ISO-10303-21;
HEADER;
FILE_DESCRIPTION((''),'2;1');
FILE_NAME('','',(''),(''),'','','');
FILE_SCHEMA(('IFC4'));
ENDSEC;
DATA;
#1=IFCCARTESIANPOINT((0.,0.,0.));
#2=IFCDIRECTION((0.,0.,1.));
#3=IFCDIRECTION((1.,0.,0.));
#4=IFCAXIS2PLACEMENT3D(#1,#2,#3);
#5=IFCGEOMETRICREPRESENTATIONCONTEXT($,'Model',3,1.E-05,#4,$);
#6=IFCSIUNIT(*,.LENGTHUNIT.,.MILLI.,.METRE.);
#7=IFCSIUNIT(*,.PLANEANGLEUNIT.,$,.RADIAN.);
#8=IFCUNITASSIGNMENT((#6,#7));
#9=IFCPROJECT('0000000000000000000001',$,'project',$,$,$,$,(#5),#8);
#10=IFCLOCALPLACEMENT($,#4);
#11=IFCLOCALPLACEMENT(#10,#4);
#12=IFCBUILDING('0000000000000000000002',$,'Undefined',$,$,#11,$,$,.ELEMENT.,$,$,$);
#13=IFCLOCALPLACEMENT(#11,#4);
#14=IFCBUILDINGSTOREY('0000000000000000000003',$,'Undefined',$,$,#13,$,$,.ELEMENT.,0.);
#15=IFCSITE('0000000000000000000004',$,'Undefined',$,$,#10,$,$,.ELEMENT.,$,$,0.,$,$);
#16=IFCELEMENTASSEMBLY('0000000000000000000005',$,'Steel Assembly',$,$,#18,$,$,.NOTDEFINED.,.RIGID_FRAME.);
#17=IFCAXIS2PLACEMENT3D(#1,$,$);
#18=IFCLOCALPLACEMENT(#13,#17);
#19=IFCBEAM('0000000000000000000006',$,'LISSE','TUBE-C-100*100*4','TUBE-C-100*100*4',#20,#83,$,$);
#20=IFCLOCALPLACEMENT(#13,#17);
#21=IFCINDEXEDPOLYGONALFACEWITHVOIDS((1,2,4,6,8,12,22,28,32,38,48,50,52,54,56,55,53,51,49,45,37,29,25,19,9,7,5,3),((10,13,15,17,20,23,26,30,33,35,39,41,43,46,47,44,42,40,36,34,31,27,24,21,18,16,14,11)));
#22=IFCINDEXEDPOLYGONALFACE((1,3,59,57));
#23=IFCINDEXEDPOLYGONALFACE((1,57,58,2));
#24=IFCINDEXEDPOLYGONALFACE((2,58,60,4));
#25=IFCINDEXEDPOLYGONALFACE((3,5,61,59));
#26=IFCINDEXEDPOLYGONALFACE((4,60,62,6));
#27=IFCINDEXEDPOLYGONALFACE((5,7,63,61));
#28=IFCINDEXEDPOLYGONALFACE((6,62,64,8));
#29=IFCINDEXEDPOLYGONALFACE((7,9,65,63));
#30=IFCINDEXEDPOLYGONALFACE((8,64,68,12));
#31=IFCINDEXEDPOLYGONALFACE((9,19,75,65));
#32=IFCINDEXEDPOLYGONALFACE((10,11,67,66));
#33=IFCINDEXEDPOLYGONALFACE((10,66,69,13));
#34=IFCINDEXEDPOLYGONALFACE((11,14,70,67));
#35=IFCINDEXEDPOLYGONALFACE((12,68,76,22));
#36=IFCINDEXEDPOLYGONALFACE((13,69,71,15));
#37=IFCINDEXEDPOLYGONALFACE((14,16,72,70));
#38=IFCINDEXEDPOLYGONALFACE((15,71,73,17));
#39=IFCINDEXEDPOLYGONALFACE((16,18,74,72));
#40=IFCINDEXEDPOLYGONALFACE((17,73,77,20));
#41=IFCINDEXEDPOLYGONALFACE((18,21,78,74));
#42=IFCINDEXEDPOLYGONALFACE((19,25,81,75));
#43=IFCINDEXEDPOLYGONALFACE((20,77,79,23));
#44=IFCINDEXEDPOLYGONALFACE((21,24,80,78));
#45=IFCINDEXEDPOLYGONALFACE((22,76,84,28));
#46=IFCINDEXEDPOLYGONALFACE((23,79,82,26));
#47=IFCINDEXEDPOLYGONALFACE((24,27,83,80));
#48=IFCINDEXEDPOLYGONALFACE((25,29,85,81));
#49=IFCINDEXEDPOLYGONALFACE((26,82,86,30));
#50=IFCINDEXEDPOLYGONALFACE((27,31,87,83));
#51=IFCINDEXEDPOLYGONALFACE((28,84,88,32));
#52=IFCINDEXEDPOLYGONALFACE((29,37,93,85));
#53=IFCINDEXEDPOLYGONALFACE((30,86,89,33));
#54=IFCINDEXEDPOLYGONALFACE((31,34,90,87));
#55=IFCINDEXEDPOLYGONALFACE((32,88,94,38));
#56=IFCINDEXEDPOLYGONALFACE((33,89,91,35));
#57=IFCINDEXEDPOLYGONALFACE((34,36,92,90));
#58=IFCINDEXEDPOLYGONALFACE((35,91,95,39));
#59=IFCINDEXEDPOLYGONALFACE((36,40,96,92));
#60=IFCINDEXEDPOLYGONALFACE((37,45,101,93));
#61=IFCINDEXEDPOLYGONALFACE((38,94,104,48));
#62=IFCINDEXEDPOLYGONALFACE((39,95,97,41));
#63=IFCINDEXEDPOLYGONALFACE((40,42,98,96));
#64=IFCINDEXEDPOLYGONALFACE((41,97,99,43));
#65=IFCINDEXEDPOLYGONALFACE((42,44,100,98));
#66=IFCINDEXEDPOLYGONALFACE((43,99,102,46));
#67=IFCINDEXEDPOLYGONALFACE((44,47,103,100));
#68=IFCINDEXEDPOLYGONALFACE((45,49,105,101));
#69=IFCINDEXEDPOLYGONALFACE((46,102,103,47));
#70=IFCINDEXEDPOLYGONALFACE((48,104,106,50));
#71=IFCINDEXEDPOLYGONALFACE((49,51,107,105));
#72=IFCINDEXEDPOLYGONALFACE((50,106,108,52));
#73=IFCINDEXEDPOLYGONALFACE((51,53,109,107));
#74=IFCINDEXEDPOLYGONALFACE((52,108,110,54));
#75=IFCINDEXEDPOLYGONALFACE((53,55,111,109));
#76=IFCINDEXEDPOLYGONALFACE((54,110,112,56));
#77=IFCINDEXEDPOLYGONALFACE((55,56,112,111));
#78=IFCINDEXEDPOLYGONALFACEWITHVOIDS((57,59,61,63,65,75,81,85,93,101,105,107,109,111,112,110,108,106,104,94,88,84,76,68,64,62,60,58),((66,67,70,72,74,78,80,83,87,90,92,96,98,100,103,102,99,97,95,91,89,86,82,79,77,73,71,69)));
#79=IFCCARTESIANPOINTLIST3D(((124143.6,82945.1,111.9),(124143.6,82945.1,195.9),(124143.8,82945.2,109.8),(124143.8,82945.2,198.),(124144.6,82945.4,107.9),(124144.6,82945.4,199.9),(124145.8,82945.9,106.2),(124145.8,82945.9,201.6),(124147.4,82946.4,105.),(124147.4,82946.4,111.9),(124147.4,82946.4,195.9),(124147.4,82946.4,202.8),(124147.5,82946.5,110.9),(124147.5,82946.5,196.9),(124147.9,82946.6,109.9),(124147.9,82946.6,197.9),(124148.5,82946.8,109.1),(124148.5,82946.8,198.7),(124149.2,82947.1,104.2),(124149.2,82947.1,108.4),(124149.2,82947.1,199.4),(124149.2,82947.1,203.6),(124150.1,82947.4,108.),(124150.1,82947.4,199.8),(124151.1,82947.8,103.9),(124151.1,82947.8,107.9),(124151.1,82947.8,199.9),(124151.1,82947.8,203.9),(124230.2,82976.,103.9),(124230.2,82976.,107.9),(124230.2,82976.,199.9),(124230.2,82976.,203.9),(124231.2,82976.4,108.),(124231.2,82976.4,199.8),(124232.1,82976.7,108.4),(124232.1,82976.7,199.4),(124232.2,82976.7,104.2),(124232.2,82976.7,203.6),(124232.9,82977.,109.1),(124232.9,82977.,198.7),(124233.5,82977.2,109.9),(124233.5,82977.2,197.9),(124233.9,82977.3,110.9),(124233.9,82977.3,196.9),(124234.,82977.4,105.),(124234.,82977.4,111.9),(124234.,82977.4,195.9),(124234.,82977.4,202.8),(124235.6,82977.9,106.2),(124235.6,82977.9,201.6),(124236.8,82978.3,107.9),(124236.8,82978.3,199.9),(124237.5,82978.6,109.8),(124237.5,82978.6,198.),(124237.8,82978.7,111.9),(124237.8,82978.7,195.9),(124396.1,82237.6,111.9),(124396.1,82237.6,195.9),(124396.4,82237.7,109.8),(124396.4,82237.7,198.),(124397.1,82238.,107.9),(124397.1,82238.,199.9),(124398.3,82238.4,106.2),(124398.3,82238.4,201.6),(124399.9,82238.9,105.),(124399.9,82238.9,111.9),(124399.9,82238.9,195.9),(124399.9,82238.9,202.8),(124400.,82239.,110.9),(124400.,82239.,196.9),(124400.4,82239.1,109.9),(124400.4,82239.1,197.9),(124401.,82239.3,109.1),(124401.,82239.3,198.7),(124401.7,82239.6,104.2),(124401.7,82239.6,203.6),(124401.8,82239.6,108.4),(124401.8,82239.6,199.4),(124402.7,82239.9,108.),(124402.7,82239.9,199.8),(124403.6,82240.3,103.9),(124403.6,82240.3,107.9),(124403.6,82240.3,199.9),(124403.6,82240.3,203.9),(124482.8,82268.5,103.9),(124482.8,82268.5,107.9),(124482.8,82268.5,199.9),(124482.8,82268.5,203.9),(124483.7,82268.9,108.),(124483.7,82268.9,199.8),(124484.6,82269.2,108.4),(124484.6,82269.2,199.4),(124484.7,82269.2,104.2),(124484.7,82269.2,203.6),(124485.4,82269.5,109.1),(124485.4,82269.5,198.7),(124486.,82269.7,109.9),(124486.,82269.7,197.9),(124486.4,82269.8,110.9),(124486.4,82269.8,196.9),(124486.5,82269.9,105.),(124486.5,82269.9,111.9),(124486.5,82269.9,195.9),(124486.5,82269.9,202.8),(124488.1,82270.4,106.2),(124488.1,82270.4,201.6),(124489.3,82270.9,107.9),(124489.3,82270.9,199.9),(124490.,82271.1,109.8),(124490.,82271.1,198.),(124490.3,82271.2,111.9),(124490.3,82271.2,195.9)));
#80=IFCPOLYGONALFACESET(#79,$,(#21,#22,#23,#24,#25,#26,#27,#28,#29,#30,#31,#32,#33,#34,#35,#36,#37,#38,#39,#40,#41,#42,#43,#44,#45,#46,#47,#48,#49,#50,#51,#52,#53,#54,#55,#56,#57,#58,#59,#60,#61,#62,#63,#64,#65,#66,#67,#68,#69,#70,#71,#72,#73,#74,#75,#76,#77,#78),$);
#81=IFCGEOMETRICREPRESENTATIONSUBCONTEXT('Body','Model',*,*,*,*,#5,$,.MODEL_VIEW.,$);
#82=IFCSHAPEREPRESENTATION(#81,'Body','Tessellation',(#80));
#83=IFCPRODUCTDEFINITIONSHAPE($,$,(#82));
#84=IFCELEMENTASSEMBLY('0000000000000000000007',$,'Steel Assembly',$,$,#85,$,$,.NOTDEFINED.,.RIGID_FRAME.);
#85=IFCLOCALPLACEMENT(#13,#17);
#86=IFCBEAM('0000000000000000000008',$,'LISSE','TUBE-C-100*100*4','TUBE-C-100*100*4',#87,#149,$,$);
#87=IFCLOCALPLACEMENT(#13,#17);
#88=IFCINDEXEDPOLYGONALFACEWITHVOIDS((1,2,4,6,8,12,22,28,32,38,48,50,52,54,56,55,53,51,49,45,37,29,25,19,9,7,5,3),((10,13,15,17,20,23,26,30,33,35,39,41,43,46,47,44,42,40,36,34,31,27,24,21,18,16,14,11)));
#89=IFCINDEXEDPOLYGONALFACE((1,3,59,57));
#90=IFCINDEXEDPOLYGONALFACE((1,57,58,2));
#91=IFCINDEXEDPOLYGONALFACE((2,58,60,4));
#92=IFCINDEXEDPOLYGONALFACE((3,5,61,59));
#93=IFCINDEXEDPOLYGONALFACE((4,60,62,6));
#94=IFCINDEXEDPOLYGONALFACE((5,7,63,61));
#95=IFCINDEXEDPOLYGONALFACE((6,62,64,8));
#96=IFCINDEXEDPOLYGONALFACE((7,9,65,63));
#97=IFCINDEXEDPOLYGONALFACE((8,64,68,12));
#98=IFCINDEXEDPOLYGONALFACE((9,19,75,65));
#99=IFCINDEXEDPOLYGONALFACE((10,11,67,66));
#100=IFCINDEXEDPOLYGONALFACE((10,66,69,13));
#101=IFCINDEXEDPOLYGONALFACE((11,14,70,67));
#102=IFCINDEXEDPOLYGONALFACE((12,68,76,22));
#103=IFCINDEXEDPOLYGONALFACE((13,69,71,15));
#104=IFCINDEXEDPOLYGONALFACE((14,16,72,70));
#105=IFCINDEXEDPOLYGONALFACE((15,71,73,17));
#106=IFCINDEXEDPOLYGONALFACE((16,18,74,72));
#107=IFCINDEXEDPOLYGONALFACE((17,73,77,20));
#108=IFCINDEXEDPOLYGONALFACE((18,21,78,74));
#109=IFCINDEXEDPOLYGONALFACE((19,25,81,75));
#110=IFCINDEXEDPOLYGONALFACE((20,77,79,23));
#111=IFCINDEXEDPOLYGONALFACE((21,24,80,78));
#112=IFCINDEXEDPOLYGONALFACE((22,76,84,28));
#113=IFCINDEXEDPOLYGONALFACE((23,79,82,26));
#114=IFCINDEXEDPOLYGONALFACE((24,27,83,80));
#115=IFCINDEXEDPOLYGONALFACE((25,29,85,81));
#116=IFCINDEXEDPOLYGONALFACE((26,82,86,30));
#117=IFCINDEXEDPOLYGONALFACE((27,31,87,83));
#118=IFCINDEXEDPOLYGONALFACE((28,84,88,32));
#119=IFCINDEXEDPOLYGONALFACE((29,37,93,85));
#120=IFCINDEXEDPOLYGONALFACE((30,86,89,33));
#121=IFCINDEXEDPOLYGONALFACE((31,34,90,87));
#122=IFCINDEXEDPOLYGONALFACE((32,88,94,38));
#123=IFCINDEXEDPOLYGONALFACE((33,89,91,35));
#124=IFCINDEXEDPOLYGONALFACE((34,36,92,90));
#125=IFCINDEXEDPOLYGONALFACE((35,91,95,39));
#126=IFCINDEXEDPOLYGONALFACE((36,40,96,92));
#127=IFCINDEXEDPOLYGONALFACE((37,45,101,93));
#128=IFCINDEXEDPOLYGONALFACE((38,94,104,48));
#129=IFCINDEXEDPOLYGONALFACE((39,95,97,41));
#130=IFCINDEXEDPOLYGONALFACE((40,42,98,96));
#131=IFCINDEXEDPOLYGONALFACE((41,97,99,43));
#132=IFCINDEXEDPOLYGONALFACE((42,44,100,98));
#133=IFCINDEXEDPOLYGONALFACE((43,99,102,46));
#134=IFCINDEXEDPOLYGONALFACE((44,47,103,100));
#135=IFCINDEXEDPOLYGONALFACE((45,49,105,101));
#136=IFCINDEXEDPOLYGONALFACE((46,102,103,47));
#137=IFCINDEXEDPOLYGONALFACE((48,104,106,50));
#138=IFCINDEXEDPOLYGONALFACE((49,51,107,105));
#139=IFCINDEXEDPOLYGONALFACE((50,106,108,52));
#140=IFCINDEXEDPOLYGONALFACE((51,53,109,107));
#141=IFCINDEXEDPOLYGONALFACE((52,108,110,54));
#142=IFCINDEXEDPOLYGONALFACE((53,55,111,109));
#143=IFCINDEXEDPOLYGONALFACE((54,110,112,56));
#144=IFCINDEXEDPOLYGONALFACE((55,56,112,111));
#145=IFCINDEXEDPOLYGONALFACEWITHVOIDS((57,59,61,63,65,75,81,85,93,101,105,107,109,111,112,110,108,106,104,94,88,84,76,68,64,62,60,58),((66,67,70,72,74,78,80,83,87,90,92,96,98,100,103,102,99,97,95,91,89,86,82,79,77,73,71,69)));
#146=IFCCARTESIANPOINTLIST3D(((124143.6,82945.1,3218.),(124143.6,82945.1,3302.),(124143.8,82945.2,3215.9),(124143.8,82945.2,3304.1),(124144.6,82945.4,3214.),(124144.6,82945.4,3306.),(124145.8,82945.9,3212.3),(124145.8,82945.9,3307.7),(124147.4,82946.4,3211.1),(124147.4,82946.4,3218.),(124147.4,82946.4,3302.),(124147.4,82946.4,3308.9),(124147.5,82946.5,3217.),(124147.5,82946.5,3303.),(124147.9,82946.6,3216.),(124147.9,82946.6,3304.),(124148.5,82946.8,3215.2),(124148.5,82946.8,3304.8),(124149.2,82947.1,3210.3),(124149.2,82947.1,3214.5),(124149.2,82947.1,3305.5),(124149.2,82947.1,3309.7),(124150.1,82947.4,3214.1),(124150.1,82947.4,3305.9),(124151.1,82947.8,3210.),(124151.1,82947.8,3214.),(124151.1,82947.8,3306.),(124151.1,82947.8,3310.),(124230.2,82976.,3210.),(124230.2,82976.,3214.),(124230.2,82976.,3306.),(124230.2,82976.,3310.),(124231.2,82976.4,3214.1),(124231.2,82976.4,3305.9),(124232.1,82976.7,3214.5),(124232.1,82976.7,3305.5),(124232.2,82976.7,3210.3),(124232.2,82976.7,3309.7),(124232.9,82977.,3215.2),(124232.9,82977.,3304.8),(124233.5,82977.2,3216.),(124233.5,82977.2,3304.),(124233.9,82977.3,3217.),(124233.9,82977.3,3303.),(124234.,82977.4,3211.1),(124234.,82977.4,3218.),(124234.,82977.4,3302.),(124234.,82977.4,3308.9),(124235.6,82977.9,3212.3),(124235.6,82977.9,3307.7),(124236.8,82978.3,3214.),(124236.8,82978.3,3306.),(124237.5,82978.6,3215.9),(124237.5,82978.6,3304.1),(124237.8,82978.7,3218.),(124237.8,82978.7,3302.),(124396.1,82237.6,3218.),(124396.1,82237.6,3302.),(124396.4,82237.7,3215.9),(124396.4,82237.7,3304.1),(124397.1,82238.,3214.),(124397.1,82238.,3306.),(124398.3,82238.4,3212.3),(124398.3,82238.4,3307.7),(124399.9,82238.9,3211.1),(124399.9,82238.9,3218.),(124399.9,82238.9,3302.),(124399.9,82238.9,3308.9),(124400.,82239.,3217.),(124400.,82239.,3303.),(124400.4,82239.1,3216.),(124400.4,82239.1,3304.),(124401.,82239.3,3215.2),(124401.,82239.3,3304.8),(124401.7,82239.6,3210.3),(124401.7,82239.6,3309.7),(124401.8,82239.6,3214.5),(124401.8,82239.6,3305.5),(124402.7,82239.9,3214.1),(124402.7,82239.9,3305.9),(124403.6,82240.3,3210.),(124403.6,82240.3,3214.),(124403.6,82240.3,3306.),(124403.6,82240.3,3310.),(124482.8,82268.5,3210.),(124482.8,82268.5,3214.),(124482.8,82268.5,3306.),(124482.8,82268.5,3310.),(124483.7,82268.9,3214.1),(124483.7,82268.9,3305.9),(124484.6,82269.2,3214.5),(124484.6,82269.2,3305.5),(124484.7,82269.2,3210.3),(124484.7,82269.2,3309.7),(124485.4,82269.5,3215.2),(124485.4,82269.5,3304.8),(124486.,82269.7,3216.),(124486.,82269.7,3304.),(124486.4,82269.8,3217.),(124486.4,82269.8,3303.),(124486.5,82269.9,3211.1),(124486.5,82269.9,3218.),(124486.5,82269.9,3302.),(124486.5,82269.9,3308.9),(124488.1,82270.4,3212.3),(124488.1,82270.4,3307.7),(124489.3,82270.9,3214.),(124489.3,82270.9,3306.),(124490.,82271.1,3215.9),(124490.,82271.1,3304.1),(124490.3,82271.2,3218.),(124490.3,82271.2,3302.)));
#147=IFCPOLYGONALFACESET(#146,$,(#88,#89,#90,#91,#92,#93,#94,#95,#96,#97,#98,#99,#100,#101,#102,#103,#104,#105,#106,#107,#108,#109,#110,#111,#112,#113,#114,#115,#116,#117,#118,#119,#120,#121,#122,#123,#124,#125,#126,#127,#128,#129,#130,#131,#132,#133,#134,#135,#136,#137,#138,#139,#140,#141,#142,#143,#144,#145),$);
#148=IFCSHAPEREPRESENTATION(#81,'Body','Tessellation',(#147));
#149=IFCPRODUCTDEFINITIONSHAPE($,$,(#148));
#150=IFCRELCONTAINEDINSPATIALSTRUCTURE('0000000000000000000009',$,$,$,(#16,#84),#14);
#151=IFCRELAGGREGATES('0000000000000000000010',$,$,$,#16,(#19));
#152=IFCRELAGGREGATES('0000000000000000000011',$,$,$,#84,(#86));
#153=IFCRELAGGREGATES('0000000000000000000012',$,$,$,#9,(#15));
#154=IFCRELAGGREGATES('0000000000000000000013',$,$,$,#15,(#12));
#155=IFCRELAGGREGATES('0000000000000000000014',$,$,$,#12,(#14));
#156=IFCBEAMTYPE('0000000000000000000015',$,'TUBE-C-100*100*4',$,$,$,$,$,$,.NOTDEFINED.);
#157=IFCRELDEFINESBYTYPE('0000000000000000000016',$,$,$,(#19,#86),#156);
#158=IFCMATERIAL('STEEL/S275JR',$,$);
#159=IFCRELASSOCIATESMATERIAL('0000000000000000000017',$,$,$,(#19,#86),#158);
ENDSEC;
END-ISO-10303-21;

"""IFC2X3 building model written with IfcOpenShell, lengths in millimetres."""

from ifc_helpers import new_model, si_unit, frame, origin_with_axes, origin_2d_with_axis, place, context, subcontext, project, spatial, hollow_rectangle, extrude, material, type_object, element, aggregate, save


model = new_model("IFC2X3")

# Units and contexts
model_context = context("Model", 3, precision=1e-05, world=origin_with_axes())
body_context = subcontext(model_context, "Body", "Model", "MODEL_VIEW")
ifc_project = project(units=[si_unit("LENGTHUNIT", "METRE", prefix="MILLI"), si_unit("PLANEANGLEUNIT", "RADIAN")], contexts=[model_context])

# Site, building, storey
site_placement = place(None, origin_with_axes())
site = spatial("IfcSite", under=ifc_project, at=site_placement, Name="Undefined", CompositionType="ELEMENT", RefElevation=0.0)
building_placement = place(site_placement, origin_with_axes())
building = spatial("IfcBuilding", under=site, at=building_placement, Name="Undefined", CompositionType="ELEMENT")
storey_placement = place(building_placement, origin_with_axes())
storey = spatial("IfcBuildingStorey", under=building, at=storey_placement, Name="Undefined", CompositionType="ELEMENT", Elevation=0.0)

# Shared definitions
ifc_material = material(Name="STEEL/S275JR")

# Element assemblies, beams
beam_type_1 = type_object("IfcBeamType", Name="TUBE-C-100*100*4", PredefinedType="NOTDEFINED")
assembly_1_placement = place(storey_placement, origin_with_axes())
assembly_1 = element("IfcElementAssembly", 1, at=assembly_1_placement, inside=storey, Name="Steel Assembly", AssemblyPlace="NOTDEFINED", PredefinedType="RIGID_FRAME")
beam_1_placement = place(assembly_1_placement, frame((124443.2, 82254.4, 153.9), z_axis=(0.941802, 0.336168, 0.0), x_axis=(-0.336168, 0.941802, 0.0)))
beam_1 = element("IfcBeam", 2, at=beam_1_placement, type_object=beam_type_1, material=ifc_material, Name="LISSE", Description="TUBE-C-100*100*4", ObjectType="TUBE-C-100*100*4", context=body_context, shape_type="SweptSolid", body=[
    extrude(hollow_rectangle(XDim=100.0, YDim=100.0, WallThickness=4.0, InnerFilletRadius=4.0, OuterFilletRadius=8.0, at=origin_2d_with_axis()), frame((751.2, 0.0, 0.0), z_axis=(-1.0, 0.0, 0.0), x_axis=(0.0, -1.0, 0.0)), (0.0, 0.0, 1.0), 751.2),
])
aggregate(assembly_1, [beam_1])
assembly_2_placement = place(storey_placement, origin_with_axes())
assembly_2 = element("IfcElementAssembly", 3, at=assembly_2_placement, inside=storey, Name="Steel Assembly", AssemblyPlace="NOTDEFINED", PredefinedType="RIGID_FRAME")
beam_2_placement = place(assembly_2_placement, frame((124443.2, 82254.4, 3260.0), z_axis=(0.941802, 0.336168, 0.0), x_axis=(-0.336168, 0.941802, 0.0)))
beam_2 = element("IfcBeam", 4, at=beam_2_placement, type_object=beam_type_1, material=ifc_material, Name="LISSE", Description="TUBE-C-100*100*4", ObjectType="TUBE-C-100*100*4", context=body_context, shape_type="SweptSolid", body=[
    extrude(hollow_rectangle(XDim=100.0, YDim=100.0, WallThickness=4.0, InnerFilletRadius=4.0, OuterFilletRadius=8.0, at=origin_2d_with_axis()), frame((751.2, 0.0, 0.0), z_axis=(-1.0, 0.0, 0.0), x_axis=(0.0, -1.0, 0.0)), (0.0, 0.0, 1.0), 751.2),
])
aggregate(assembly_2, [beam_2])

save(model, "model.ifc")
